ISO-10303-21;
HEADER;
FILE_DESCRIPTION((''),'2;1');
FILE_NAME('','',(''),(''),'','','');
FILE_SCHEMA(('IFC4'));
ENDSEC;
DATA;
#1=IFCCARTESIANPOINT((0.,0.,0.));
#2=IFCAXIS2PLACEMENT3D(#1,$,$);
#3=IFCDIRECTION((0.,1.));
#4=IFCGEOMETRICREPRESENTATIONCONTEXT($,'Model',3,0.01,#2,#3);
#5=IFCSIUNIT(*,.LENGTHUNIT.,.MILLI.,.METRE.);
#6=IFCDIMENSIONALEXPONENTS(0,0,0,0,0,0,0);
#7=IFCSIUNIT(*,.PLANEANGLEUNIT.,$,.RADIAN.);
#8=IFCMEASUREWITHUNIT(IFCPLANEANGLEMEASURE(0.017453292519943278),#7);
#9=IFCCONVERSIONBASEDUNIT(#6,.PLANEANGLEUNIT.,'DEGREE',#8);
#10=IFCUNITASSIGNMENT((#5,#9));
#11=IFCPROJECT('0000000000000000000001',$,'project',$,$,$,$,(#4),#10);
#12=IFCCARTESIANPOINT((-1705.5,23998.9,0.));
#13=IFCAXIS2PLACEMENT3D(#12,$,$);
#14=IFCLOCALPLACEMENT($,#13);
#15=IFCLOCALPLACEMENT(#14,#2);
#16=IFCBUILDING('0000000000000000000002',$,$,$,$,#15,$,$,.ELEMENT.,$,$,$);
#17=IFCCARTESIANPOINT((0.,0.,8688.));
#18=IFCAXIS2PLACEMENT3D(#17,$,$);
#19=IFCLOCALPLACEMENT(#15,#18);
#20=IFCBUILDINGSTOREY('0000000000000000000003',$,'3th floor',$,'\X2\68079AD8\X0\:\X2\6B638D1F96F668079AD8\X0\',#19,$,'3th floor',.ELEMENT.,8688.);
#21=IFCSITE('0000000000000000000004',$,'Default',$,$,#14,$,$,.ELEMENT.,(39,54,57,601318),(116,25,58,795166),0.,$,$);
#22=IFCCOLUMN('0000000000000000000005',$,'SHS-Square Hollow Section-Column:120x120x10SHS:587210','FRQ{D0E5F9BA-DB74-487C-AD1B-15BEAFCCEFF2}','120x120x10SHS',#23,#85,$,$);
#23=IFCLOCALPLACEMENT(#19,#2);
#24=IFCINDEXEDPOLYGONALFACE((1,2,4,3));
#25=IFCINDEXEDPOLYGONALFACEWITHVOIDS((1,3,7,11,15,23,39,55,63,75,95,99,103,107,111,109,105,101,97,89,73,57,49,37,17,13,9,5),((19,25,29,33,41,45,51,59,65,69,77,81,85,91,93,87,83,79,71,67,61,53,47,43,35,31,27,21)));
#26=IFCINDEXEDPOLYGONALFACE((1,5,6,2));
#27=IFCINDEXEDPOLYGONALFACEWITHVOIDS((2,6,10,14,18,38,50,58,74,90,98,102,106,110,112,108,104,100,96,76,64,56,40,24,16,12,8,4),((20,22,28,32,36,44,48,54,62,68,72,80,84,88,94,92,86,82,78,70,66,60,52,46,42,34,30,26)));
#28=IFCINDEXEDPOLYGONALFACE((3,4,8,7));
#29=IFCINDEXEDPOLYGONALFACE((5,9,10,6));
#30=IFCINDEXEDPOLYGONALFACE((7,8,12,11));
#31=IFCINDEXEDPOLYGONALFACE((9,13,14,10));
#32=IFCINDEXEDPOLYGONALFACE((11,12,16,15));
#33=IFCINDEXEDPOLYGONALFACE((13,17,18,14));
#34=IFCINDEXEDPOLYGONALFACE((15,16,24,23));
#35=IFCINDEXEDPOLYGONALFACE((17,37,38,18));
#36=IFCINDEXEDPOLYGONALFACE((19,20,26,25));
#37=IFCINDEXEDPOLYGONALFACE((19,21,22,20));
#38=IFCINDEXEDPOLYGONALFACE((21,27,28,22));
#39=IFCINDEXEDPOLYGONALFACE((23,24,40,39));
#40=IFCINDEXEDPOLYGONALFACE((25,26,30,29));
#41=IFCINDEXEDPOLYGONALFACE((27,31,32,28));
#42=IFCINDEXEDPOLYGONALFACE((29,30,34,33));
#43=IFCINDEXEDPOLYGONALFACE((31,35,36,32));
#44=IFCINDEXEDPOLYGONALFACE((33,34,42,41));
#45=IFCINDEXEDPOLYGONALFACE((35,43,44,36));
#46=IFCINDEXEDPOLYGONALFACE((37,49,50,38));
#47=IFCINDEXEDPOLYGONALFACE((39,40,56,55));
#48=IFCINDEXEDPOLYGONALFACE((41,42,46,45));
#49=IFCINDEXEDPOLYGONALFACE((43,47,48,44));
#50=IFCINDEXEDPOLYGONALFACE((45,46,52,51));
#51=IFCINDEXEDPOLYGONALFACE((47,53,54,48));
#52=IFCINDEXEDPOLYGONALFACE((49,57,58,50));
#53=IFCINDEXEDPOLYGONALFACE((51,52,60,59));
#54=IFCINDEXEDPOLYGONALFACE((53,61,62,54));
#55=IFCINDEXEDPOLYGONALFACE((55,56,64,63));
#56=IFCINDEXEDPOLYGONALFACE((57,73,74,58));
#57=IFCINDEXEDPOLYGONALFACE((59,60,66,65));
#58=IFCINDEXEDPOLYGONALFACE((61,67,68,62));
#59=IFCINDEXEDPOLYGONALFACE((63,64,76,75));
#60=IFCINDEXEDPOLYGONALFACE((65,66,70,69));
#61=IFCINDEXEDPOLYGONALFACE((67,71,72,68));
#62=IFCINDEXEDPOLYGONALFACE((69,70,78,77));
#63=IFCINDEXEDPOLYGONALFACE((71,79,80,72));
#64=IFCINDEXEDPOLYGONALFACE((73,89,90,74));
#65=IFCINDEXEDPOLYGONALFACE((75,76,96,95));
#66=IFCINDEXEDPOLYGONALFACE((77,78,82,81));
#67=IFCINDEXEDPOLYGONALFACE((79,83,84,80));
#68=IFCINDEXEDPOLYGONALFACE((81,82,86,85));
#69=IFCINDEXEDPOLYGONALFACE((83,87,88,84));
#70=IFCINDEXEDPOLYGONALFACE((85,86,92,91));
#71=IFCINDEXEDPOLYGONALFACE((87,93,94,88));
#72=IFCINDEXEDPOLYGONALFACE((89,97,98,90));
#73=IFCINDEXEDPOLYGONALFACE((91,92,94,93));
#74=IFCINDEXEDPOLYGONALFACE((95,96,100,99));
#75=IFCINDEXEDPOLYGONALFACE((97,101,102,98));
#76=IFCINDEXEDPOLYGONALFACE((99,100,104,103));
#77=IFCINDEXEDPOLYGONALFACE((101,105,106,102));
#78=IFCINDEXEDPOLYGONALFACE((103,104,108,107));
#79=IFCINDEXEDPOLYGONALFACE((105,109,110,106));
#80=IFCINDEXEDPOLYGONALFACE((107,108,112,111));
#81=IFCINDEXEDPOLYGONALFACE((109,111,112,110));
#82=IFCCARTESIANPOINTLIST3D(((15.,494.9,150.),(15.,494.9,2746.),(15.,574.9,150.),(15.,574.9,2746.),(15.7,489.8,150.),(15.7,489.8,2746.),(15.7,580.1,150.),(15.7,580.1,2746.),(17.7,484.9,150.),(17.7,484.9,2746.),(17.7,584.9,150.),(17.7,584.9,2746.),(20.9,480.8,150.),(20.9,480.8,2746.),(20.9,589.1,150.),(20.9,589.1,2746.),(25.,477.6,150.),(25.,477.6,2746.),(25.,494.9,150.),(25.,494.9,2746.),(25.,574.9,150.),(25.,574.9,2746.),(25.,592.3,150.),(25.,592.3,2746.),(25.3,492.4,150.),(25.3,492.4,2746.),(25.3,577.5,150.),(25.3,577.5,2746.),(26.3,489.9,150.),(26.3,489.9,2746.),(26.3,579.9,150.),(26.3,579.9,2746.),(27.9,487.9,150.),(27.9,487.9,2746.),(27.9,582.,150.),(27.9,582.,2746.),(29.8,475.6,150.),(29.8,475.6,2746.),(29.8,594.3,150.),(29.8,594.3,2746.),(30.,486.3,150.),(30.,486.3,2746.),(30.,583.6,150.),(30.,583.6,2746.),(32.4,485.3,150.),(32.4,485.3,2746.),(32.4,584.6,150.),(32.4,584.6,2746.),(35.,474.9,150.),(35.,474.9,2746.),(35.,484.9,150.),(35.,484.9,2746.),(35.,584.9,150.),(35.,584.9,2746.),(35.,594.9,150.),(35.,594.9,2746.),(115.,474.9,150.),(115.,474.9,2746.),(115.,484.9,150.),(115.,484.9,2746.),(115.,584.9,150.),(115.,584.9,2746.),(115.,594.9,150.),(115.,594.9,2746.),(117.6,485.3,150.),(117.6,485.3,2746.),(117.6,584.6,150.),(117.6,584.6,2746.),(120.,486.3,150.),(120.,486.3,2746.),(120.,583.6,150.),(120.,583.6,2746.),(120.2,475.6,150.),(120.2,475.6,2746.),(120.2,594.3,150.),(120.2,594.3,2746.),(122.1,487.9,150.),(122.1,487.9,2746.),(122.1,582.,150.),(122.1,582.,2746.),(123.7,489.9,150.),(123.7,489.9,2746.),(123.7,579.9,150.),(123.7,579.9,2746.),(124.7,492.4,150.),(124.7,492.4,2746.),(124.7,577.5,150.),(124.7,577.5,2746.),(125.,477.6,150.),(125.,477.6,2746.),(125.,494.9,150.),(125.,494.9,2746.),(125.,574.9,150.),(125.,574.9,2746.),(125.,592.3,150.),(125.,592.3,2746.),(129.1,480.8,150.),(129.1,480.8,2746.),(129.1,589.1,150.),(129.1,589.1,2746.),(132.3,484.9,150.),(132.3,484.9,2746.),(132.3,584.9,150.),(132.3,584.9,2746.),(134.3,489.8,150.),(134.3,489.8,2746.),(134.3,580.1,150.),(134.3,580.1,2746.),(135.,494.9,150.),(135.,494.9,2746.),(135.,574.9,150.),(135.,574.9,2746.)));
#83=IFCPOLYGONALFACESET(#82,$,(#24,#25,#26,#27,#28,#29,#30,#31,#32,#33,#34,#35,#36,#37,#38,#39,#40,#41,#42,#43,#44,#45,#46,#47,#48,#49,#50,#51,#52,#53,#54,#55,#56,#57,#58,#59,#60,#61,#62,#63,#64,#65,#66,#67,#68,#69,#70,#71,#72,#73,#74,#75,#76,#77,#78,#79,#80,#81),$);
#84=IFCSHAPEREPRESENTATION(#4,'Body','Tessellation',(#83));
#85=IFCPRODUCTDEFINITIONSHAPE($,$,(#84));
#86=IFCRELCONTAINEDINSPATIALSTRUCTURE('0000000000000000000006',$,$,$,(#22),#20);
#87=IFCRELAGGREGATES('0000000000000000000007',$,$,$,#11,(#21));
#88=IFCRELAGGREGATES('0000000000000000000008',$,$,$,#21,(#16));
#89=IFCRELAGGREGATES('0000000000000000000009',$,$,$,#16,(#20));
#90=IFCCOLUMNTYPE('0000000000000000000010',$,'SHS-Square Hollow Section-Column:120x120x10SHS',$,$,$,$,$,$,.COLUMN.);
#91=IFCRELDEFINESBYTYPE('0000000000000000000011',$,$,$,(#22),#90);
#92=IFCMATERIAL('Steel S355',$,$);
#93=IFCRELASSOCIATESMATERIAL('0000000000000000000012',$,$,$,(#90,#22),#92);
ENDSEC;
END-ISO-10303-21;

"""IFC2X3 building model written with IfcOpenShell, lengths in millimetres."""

from ifc_helpers import new_model, entity, si_unit, converted_unit, direction, frame, origin, origin_2d, place, context, project, spatial, hollow_rectangle, extrude, clip, halfspace, material, type_object, element, save


model = new_model("IFC2X3")

# Units and contexts
model_context = context("Model", 3, precision=0.01, world=origin(), true_north=direction((0.0, 1.0)))
ifc_project = project(units=[si_unit("LENGTHUNIT", "METRE", prefix="MILLI"), converted_unit("PLANEANGLEUNIT", "DEGREE", entity("IfcPlaneAngleMeasure", 0.017453292519943278), si_unit("PLANEANGLEUNIT", "RADIAN"), dimensions=[0, 0, 0, 0, 0, 0, 0])], contexts=[model_context])

# Site, building, storey
site_placement = place(None, frame((-1705.5, 23998.9, 0.0)))
site = spatial("IfcSite", under=ifc_project, at=site_placement, Name="Default", CompositionType="ELEMENT", RefLatitude=(39, 54, 57, 601318), RefLongitude=(116, 25, 58, 795166), RefElevation=0.0)
building_placement = place(site_placement, origin())
building = spatial("IfcBuilding", under=site, at=building_placement, CompositionType="ELEMENT")
storey_placement = place(building_placement, frame((0.0, 0.0, 8688.0)))
storey = spatial("IfcBuildingStorey", under=building, at=storey_placement, Name="3th floor", ObjectType="标高:正负零标高", LongName="3th floor", CompositionType="ELEMENT", Elevation=8688.0)

# Column
ifc_material_1 = material(Name="Steel S355")
column_type_1 = type_object("IfcColumnType", Name="SHS-Square Hollow Section-Column:120x120x10SHS", PredefinedType="COLUMN", material=ifc_material_1)
column_1_placement = place(storey_placement, frame((75.0, 534.9, 2746.0), z_axis=(0.0, 0.0, 1.0), x_axis=(0.0, -1.0, 0.0)))
element("IfcColumn", 1, at=column_1_placement, inside=storey, type_object=column_type_1, material=ifc_material_1, Name="SHS-Square Hollow Section-Column:120x120x10SHS:587210", Description="FRQ{D0E5F9BA-DB74-487C-AD1B-15BEAFCCEFF2}", ObjectType="120x120x10SHS", context=model_context, shape_type="Clipping", body=[
    clip(extrude(hollow_rectangle(XDim=120.0, YDim=120.0, WallThickness=10.0, InnerFilletRadius=10.0, OuterFilletRadius=20.0, at=origin_2d()), origin(), (0.0, 0.0, -1.0), 2680.9), halfspace(frame((534.9, -75.0, -2596.0), z_axis=(0.0, 0.0, 1.0), x_axis=(0.0, 1.0, 0.0)), True)),
])

save(model, "model.ifc")
